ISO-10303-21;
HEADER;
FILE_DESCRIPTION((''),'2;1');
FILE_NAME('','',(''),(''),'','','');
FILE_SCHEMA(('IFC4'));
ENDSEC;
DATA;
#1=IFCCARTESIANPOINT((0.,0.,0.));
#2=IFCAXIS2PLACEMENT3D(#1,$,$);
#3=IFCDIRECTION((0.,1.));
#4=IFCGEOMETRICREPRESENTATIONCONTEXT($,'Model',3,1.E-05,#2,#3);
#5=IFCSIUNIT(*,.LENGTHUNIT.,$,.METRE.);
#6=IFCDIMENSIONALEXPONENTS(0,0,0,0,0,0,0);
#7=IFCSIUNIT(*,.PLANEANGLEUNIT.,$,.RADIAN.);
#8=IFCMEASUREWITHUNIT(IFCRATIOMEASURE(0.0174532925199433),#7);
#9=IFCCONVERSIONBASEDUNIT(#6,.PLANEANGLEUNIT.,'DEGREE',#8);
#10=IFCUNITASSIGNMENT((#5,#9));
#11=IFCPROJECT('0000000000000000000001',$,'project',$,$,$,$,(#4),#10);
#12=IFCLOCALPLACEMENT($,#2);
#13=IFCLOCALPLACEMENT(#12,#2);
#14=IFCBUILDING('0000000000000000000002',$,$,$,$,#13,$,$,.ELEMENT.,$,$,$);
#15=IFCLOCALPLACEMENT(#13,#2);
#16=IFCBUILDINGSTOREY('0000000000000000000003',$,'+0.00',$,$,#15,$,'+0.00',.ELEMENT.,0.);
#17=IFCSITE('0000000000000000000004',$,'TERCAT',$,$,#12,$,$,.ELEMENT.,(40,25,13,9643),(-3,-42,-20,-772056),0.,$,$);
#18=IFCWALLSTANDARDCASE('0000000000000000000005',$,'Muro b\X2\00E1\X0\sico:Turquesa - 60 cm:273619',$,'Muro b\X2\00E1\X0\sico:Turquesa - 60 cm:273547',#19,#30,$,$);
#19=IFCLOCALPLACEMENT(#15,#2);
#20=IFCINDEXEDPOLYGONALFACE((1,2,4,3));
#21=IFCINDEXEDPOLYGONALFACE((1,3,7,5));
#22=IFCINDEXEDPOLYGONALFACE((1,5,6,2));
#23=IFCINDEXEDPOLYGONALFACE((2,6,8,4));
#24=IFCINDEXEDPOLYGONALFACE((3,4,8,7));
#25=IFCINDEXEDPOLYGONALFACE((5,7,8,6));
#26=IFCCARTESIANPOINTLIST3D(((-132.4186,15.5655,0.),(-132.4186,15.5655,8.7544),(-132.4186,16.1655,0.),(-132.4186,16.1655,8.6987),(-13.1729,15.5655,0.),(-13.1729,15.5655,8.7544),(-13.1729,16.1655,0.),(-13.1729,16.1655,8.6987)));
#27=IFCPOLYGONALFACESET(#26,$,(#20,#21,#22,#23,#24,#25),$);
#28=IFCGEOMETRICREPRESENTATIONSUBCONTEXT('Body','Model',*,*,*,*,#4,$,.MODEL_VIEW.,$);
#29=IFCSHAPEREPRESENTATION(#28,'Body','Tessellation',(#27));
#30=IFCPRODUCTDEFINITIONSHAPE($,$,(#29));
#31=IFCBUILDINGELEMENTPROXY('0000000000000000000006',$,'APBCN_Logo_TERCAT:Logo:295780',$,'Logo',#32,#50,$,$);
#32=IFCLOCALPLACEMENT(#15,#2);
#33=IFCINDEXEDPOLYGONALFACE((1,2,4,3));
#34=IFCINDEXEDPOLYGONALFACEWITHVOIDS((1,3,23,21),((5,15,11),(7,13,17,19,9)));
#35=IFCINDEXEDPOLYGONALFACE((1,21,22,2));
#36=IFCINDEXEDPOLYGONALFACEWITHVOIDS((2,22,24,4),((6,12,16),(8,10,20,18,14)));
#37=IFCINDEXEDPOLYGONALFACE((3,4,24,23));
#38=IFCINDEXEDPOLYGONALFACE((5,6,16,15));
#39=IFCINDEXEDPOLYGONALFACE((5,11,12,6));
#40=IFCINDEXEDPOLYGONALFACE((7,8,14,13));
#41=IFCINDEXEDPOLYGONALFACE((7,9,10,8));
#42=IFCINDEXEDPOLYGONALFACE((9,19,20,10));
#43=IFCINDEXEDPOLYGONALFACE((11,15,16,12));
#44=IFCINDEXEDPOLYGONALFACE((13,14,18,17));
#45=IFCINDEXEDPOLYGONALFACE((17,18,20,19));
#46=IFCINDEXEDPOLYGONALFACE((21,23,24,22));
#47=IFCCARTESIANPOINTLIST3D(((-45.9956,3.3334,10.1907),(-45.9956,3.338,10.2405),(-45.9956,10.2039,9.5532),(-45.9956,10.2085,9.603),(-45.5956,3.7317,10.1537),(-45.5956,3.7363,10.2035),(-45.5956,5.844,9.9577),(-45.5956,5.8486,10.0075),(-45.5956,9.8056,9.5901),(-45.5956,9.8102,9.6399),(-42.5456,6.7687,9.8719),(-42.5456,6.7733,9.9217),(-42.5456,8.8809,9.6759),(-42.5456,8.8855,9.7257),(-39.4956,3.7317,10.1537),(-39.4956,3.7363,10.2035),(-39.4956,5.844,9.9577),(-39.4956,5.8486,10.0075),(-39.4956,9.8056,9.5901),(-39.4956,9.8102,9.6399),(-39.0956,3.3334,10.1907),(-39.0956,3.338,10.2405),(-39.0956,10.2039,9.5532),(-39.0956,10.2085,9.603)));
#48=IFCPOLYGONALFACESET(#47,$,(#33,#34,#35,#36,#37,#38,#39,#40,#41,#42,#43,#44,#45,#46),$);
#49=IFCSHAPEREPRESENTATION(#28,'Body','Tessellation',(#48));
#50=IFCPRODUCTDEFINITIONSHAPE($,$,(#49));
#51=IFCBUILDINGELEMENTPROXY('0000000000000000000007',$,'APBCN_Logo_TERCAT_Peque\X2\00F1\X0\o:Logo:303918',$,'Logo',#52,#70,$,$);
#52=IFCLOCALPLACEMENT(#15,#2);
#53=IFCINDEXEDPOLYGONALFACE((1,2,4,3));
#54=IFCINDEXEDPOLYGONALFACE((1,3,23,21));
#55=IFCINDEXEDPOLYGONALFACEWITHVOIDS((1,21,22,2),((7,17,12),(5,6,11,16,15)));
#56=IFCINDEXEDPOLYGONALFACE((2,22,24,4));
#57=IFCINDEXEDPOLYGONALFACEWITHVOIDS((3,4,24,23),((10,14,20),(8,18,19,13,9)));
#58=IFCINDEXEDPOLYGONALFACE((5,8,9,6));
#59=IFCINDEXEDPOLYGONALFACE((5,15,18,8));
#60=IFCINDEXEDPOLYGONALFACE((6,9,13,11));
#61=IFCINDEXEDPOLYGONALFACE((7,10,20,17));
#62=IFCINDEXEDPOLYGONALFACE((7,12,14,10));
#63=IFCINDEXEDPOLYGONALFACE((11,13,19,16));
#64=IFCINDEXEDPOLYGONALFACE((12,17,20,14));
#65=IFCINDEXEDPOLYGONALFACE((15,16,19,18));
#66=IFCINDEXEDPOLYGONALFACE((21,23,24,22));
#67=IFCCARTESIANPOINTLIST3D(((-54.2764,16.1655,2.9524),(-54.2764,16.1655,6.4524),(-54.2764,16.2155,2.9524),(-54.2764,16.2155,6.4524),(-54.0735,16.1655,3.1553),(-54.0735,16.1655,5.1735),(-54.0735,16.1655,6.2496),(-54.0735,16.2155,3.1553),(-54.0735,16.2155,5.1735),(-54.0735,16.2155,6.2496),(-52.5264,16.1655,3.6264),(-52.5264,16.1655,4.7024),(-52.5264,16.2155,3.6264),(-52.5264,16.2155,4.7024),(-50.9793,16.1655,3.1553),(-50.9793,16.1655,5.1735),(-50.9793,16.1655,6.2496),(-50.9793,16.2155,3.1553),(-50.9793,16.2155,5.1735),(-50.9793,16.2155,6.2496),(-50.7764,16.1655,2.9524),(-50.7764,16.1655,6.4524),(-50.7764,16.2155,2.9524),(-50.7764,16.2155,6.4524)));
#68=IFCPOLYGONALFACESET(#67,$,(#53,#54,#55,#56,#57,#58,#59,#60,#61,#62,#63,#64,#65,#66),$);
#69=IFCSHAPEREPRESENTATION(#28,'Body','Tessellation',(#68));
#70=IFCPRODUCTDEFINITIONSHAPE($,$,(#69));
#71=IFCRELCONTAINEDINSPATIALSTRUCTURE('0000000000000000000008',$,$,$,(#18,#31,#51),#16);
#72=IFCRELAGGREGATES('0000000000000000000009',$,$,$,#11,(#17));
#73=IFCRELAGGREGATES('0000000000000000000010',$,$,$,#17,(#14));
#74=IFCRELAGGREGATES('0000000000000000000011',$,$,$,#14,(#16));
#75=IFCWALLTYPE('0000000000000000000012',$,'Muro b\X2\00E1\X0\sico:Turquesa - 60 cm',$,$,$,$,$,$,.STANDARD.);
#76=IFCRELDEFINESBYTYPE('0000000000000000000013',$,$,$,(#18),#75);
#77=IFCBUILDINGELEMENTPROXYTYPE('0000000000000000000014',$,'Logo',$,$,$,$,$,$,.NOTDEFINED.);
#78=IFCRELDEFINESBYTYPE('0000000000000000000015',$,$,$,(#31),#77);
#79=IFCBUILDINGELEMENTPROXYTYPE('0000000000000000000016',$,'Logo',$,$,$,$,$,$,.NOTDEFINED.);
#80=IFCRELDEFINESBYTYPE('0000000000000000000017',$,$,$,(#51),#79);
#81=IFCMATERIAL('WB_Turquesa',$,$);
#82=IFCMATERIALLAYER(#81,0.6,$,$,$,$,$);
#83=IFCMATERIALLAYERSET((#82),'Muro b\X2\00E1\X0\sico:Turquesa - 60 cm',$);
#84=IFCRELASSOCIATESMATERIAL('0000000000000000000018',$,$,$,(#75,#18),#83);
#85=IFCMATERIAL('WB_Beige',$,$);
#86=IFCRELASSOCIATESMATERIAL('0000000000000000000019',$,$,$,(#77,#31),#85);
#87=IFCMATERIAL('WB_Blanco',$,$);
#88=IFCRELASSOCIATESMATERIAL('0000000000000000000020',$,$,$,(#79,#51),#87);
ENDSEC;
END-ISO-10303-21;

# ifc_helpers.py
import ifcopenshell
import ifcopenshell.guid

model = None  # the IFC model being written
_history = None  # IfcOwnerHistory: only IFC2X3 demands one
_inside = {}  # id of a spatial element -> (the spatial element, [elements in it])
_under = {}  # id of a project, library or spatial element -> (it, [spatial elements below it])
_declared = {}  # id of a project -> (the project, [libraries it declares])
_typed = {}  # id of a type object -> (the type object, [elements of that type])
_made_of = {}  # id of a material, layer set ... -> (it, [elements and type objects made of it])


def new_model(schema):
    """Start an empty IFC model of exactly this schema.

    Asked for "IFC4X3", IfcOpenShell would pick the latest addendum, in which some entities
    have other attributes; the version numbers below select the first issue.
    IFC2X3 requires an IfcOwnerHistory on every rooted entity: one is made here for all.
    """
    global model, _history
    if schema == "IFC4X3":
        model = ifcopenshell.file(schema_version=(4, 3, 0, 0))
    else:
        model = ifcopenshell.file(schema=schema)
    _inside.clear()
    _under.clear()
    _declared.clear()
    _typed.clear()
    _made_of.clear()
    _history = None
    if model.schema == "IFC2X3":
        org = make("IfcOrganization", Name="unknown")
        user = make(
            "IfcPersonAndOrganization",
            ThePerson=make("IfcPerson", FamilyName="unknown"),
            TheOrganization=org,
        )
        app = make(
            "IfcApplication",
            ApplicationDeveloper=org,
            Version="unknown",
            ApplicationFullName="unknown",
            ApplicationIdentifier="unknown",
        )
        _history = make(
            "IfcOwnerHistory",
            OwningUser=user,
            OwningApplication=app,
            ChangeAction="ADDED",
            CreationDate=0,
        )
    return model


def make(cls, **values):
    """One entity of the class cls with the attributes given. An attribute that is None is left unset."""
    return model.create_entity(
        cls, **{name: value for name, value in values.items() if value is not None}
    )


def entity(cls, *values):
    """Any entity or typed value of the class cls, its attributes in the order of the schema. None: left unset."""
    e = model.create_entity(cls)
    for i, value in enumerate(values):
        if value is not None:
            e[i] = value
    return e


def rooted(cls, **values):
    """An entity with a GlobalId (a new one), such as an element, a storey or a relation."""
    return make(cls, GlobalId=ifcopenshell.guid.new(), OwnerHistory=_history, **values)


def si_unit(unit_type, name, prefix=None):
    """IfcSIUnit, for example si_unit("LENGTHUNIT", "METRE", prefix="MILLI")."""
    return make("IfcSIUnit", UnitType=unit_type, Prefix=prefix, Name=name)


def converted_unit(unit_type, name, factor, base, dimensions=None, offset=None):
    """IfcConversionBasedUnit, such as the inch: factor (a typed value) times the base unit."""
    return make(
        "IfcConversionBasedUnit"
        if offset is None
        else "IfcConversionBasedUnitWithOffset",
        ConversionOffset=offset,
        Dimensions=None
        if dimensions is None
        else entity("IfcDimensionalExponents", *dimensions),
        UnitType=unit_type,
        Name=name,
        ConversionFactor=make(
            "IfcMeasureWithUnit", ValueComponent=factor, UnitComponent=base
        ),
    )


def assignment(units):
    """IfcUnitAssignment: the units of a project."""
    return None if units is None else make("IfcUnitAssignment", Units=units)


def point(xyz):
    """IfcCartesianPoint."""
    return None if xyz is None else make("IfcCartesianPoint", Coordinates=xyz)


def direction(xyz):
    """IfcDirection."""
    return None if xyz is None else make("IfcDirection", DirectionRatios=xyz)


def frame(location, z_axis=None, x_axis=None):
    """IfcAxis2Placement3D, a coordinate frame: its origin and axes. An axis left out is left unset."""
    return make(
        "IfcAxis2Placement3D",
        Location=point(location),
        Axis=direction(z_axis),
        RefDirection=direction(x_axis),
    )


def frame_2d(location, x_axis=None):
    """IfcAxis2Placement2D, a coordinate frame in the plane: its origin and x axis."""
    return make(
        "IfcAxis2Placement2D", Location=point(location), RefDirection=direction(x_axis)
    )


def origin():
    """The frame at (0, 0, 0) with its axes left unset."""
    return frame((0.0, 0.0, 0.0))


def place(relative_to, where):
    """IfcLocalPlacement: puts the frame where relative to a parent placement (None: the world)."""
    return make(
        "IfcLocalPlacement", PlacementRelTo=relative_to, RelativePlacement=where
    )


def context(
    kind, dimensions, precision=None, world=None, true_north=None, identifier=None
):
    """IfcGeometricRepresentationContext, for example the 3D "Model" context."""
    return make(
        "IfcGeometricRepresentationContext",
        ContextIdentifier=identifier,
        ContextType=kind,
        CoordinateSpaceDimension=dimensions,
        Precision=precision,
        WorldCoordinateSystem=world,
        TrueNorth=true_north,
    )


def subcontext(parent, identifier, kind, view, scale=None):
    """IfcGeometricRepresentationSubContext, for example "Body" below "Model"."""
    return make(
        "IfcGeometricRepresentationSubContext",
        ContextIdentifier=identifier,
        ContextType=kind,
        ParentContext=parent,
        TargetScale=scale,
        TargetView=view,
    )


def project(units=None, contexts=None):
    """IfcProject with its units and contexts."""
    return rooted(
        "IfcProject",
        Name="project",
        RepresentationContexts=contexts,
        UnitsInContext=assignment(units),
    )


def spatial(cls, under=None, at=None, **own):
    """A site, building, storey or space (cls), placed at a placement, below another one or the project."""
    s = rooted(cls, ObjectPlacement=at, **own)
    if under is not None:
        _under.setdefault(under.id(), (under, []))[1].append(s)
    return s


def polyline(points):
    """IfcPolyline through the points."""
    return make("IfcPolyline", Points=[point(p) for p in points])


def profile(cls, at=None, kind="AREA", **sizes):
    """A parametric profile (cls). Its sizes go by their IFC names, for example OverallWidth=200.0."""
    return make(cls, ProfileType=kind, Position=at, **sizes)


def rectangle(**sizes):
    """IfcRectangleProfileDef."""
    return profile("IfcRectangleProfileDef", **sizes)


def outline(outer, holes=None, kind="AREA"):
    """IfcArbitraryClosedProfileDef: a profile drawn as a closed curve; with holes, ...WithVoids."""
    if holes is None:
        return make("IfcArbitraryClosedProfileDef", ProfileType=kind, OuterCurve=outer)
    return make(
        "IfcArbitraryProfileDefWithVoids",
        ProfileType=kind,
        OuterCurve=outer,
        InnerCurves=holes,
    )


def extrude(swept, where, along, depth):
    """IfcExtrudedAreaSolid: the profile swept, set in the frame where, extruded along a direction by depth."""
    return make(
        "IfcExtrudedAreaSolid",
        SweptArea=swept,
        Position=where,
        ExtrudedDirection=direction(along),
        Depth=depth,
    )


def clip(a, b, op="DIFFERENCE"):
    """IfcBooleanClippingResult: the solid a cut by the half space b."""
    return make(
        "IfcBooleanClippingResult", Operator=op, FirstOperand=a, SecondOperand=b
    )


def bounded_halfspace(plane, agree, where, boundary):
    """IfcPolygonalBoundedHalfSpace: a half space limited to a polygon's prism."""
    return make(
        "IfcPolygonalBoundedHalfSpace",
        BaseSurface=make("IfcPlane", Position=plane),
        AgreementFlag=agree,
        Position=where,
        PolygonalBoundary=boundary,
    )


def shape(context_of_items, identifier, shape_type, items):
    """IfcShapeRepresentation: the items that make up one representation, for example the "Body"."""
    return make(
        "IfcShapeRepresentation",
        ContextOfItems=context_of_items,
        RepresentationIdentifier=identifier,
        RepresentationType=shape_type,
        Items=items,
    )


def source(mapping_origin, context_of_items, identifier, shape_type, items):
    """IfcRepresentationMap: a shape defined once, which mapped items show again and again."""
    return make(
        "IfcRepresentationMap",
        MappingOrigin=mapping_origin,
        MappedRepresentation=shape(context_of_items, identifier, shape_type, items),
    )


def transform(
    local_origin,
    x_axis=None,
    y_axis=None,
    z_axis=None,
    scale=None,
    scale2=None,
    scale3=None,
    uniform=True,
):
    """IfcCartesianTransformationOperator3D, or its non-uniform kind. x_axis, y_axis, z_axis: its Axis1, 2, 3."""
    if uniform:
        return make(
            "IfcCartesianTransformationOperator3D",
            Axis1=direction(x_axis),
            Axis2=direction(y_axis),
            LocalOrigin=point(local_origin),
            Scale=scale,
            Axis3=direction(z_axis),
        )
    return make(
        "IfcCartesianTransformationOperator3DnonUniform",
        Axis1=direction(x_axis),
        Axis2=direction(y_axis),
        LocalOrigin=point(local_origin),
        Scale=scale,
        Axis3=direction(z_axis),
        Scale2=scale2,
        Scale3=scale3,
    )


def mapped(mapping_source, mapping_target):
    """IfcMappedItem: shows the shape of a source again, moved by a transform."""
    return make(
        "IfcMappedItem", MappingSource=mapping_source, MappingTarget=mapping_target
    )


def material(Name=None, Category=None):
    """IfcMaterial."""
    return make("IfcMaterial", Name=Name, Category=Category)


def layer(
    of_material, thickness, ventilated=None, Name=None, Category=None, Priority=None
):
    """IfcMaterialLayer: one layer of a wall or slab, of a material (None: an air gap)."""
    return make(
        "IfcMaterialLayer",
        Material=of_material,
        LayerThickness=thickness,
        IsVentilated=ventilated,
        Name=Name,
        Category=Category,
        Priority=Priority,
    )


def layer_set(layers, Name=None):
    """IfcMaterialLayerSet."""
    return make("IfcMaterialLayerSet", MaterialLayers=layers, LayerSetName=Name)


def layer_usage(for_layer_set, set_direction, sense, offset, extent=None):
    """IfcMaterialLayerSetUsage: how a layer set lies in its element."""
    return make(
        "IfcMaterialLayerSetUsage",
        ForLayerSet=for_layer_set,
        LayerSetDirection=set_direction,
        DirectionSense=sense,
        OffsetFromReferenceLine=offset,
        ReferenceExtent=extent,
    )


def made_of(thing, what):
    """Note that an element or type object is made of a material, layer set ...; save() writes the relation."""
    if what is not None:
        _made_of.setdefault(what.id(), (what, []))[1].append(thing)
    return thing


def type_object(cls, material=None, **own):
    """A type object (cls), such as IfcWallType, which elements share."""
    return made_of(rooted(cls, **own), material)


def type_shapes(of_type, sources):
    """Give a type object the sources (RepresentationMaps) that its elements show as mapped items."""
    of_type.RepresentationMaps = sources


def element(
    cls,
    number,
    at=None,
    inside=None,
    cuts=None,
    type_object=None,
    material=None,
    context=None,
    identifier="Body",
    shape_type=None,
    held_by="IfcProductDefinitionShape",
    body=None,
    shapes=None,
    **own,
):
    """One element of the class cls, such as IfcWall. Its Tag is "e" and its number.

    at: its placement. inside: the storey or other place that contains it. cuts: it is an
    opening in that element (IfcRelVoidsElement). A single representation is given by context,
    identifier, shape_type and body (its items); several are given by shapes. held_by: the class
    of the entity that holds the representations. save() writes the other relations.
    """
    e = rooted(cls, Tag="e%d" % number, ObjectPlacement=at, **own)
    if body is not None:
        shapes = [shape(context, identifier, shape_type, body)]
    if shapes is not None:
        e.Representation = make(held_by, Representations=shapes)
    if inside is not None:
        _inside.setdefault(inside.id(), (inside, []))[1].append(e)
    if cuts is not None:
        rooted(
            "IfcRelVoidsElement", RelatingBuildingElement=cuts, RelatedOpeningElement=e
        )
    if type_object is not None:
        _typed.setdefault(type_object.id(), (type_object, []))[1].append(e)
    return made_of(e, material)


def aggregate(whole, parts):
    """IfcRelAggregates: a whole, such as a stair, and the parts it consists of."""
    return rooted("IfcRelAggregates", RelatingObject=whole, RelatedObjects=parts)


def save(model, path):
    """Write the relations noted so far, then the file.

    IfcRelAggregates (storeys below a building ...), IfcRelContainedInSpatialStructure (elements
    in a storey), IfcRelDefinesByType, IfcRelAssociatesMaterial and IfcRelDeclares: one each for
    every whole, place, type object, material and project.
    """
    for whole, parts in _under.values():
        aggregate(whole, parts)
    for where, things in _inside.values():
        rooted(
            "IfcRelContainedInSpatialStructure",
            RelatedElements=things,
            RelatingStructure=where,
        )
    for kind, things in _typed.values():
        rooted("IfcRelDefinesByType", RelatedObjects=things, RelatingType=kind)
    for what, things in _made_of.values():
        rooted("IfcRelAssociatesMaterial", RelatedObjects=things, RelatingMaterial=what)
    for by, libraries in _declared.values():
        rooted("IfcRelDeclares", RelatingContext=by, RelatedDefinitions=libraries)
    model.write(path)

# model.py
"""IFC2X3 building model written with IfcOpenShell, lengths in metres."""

from ifc_helpers import new_model, entity, si_unit, converted_unit, direction, frame, frame_2d, origin, place, context, subcontext, project, spatial, polyline, rectangle, outline, extrude, clip, bounded_halfspace, source, transform, mapped, material, layer, layer_set, layer_usage, type_object, type_shapes, element, save


model = new_model("IFC2X3")

# Units and contexts
model_context = context("Model", 3, precision=1e-05, world=origin(), true_north=direction((0.0, 1.0)))
body_context = subcontext(model_context, "Body", "Model", "MODEL_VIEW")
ifc_project = project(units=[si_unit("LENGTHUNIT", "METRE"), converted_unit("PLANEANGLEUNIT", "DEGREE", entity("IfcRatioMeasure", 0.0174532925199433), si_unit("PLANEANGLEUNIT", "RADIAN"), dimensions=[0, 0, 0, 0, 0, 0, 0])], contexts=[model_context])

# Site, building, storey
site_placement = place(None, origin())
site = spatial("IfcSite", under=ifc_project, at=site_placement, Name="TERCAT", CompositionType="ELEMENT", RefLatitude=(40, 25, 13, 9643), RefLongitude=(-3, -42, -20, -772056), RefElevation=0.0)
building_placement = place(site_placement, origin())
building = spatial("IfcBuilding", under=site, at=building_placement, CompositionType="ELEMENT")
storey_placement = place(building_placement, origin())
storey = spatial("IfcBuildingStorey", under=building, at=storey_placement, Name="+0.00", LongName="+0.00", CompositionType="ELEMENT", Elevation=0.0)

# Wall
ifc_material_1 = material(Name="WB_Turquesa")
ifc_layer = layer(ifc_material_1, 0.6)
ifc_layer_set = layer_set([ifc_layer], Name="Muro básico:Turquesa - 60 cm")
ifc_layer_usage = layer_usage(ifc_layer_set, "AXIS2", "POSITIVE", -0.3)
wall_type = type_object("IfcWallType", Name="Muro básico:Turquesa - 60 cm", PredefinedType="STANDARD", material=ifc_layer_set)
wall_placement = place(storey_placement, frame((-13.1729, 15.8655, 0.0), z_axis=(0.0, 0.0, 1.0), x_axis=(-1.0, 0.0, 0.0)))
element("IfcWallStandardCase", 1, at=wall_placement, inside=storey, type_object=wall_type, material=ifc_layer_usage, Name="Muro básico:Turquesa - 60 cm:273619", ObjectType="Muro básico:Turquesa - 60 cm:273547", context=body_context, shape_type="Clipping", body=[
    clip(extrude(rectangle(XDim=119.2457, YDim=0.6, at=frame_2d((59.6228, 0.0), x_axis=(-1.0, 0.0))), origin(), (0.0, 0.0, 1.0), 8.7544), bounded_halfspace(frame((0.0, -0.3, 8.6987), z_axis=(0.0, -0.092394, 0.995723), x_axis=(0.0, -0.995723, -0.092394)), False, frame((0.0, -0.3, 8.6987), z_axis=(0.0, -0.092394, 0.995723), x_axis=(0.0, -0.995723, -0.092394)), polyline([(0.0, 0.0), (0.0, 119.2457), (-0.6026, 119.2457), (-0.6026, 118.6457), (-0.6026, 0.0), (0.0, 0.0)]))),
])

# Building element proxies
ifc_material_2 = material(Name="WB_Beige")
building_element_proxy_type_1 = type_object("IfcBuildingElementProxyType", Name="Logo", PredefinedType="NOTDEFINED", material=ifc_material_2)
shared_shape_1 = source(origin(), body_context, "Body", "SweptSolid", [
    extrude(outline(polyline([(-3.45, -3.45), (3.45, -3.45), (3.45, 3.45), (-3.45, 3.45), (-3.45, -3.45)]), holes=[polyline([(3.05, -0.9287), (0.0, 2.1213), (-3.05, -0.9287), (-3.05, 3.05), (3.05, 3.05), (3.05, -0.9287)]), polyline([(-3.05, -3.05), (0.0, 0.0), (3.05, -3.05), (-3.05, -3.05)])]), frame((0.0, 0.0, 0.0), z_axis=(0.0, 0.0, 1.0), x_axis=(-1.0, 0.0, 0.0)), (0.0, 0.0, 1.0), 0.05),
])
type_shapes(building_element_proxy_type_1, [shared_shape_1])
proxy_1_placement = place(storey_placement, frame((-42.5456, 6.7687, 9.8719), z_axis=(0.0, 0.092394, 0.995723), x_axis=(-1.0, 0.0, 0.0)))
element("IfcBuildingElementProxy", 2, at=proxy_1_placement, inside=storey, type_object=building_element_proxy_type_1, material=ifc_material_2, Name="APBCN_Logo_TERCAT:Logo:295780", ObjectType="Logo", context=body_context, shape_type="MappedRepresentation", body=[
    mapped(shared_shape_1, transform((0.0, 0.0, 0.0), scale=1.0)),
])
ifc_material_3 = material(Name="WB_Blanco")
building_element_proxy_type_2 = type_object("IfcBuildingElementProxyType", Name="Logo", PredefinedType="NOTDEFINED", material=ifc_material_3)
shared_shape_2 = source(origin(), body_context, "Body", "SweptSolid", [
    extrude(outline(polyline([(-1.75, -1.75), (1.75, -1.75), (1.75, 1.75), (-1.75, 1.75), (-1.75, -1.75)]), holes=[polyline([(1.5471, -0.4711), (0.0, 1.076), (-1.5471, -0.4711), (-1.5471, 1.5471), (1.5471, 1.5471), (1.5471, -0.4711)]), polyline([(-1.5471, -1.5471), (0.0, 0.0), (1.5471, -1.5471), (-1.5471, -1.5471)])]), frame((0.0, 0.0, 0.0), z_axis=(0.0, 0.0, 1.0), x_axis=(-1.0, 0.0, 0.0)), (0.0, 0.0, 1.0), 0.05),
])
type_shapes(building_element_proxy_type_2, [shared_shape_2])
proxy_2_placement = place(storey_placement, frame((-52.5264, 16.1655, 4.7024), z_axis=(0.0, 1.0, 0.0), x_axis=(-1.0, 0.0, 0.0)))
element("IfcBuildingElementProxy", 3, at=proxy_2_placement, inside=storey, type_object=building_element_proxy_type_2, material=ifc_material_3, Name="APBCN_Logo_TERCAT_Pequeño:Logo:303918", ObjectType="Logo", context=body_context, shape_type="MappedRepresentation", body=[
    mapped(shared_shape_2, transform((0.0, 0.0, 0.0), scale=1.0)),
])

save(model, "model.ifc")
